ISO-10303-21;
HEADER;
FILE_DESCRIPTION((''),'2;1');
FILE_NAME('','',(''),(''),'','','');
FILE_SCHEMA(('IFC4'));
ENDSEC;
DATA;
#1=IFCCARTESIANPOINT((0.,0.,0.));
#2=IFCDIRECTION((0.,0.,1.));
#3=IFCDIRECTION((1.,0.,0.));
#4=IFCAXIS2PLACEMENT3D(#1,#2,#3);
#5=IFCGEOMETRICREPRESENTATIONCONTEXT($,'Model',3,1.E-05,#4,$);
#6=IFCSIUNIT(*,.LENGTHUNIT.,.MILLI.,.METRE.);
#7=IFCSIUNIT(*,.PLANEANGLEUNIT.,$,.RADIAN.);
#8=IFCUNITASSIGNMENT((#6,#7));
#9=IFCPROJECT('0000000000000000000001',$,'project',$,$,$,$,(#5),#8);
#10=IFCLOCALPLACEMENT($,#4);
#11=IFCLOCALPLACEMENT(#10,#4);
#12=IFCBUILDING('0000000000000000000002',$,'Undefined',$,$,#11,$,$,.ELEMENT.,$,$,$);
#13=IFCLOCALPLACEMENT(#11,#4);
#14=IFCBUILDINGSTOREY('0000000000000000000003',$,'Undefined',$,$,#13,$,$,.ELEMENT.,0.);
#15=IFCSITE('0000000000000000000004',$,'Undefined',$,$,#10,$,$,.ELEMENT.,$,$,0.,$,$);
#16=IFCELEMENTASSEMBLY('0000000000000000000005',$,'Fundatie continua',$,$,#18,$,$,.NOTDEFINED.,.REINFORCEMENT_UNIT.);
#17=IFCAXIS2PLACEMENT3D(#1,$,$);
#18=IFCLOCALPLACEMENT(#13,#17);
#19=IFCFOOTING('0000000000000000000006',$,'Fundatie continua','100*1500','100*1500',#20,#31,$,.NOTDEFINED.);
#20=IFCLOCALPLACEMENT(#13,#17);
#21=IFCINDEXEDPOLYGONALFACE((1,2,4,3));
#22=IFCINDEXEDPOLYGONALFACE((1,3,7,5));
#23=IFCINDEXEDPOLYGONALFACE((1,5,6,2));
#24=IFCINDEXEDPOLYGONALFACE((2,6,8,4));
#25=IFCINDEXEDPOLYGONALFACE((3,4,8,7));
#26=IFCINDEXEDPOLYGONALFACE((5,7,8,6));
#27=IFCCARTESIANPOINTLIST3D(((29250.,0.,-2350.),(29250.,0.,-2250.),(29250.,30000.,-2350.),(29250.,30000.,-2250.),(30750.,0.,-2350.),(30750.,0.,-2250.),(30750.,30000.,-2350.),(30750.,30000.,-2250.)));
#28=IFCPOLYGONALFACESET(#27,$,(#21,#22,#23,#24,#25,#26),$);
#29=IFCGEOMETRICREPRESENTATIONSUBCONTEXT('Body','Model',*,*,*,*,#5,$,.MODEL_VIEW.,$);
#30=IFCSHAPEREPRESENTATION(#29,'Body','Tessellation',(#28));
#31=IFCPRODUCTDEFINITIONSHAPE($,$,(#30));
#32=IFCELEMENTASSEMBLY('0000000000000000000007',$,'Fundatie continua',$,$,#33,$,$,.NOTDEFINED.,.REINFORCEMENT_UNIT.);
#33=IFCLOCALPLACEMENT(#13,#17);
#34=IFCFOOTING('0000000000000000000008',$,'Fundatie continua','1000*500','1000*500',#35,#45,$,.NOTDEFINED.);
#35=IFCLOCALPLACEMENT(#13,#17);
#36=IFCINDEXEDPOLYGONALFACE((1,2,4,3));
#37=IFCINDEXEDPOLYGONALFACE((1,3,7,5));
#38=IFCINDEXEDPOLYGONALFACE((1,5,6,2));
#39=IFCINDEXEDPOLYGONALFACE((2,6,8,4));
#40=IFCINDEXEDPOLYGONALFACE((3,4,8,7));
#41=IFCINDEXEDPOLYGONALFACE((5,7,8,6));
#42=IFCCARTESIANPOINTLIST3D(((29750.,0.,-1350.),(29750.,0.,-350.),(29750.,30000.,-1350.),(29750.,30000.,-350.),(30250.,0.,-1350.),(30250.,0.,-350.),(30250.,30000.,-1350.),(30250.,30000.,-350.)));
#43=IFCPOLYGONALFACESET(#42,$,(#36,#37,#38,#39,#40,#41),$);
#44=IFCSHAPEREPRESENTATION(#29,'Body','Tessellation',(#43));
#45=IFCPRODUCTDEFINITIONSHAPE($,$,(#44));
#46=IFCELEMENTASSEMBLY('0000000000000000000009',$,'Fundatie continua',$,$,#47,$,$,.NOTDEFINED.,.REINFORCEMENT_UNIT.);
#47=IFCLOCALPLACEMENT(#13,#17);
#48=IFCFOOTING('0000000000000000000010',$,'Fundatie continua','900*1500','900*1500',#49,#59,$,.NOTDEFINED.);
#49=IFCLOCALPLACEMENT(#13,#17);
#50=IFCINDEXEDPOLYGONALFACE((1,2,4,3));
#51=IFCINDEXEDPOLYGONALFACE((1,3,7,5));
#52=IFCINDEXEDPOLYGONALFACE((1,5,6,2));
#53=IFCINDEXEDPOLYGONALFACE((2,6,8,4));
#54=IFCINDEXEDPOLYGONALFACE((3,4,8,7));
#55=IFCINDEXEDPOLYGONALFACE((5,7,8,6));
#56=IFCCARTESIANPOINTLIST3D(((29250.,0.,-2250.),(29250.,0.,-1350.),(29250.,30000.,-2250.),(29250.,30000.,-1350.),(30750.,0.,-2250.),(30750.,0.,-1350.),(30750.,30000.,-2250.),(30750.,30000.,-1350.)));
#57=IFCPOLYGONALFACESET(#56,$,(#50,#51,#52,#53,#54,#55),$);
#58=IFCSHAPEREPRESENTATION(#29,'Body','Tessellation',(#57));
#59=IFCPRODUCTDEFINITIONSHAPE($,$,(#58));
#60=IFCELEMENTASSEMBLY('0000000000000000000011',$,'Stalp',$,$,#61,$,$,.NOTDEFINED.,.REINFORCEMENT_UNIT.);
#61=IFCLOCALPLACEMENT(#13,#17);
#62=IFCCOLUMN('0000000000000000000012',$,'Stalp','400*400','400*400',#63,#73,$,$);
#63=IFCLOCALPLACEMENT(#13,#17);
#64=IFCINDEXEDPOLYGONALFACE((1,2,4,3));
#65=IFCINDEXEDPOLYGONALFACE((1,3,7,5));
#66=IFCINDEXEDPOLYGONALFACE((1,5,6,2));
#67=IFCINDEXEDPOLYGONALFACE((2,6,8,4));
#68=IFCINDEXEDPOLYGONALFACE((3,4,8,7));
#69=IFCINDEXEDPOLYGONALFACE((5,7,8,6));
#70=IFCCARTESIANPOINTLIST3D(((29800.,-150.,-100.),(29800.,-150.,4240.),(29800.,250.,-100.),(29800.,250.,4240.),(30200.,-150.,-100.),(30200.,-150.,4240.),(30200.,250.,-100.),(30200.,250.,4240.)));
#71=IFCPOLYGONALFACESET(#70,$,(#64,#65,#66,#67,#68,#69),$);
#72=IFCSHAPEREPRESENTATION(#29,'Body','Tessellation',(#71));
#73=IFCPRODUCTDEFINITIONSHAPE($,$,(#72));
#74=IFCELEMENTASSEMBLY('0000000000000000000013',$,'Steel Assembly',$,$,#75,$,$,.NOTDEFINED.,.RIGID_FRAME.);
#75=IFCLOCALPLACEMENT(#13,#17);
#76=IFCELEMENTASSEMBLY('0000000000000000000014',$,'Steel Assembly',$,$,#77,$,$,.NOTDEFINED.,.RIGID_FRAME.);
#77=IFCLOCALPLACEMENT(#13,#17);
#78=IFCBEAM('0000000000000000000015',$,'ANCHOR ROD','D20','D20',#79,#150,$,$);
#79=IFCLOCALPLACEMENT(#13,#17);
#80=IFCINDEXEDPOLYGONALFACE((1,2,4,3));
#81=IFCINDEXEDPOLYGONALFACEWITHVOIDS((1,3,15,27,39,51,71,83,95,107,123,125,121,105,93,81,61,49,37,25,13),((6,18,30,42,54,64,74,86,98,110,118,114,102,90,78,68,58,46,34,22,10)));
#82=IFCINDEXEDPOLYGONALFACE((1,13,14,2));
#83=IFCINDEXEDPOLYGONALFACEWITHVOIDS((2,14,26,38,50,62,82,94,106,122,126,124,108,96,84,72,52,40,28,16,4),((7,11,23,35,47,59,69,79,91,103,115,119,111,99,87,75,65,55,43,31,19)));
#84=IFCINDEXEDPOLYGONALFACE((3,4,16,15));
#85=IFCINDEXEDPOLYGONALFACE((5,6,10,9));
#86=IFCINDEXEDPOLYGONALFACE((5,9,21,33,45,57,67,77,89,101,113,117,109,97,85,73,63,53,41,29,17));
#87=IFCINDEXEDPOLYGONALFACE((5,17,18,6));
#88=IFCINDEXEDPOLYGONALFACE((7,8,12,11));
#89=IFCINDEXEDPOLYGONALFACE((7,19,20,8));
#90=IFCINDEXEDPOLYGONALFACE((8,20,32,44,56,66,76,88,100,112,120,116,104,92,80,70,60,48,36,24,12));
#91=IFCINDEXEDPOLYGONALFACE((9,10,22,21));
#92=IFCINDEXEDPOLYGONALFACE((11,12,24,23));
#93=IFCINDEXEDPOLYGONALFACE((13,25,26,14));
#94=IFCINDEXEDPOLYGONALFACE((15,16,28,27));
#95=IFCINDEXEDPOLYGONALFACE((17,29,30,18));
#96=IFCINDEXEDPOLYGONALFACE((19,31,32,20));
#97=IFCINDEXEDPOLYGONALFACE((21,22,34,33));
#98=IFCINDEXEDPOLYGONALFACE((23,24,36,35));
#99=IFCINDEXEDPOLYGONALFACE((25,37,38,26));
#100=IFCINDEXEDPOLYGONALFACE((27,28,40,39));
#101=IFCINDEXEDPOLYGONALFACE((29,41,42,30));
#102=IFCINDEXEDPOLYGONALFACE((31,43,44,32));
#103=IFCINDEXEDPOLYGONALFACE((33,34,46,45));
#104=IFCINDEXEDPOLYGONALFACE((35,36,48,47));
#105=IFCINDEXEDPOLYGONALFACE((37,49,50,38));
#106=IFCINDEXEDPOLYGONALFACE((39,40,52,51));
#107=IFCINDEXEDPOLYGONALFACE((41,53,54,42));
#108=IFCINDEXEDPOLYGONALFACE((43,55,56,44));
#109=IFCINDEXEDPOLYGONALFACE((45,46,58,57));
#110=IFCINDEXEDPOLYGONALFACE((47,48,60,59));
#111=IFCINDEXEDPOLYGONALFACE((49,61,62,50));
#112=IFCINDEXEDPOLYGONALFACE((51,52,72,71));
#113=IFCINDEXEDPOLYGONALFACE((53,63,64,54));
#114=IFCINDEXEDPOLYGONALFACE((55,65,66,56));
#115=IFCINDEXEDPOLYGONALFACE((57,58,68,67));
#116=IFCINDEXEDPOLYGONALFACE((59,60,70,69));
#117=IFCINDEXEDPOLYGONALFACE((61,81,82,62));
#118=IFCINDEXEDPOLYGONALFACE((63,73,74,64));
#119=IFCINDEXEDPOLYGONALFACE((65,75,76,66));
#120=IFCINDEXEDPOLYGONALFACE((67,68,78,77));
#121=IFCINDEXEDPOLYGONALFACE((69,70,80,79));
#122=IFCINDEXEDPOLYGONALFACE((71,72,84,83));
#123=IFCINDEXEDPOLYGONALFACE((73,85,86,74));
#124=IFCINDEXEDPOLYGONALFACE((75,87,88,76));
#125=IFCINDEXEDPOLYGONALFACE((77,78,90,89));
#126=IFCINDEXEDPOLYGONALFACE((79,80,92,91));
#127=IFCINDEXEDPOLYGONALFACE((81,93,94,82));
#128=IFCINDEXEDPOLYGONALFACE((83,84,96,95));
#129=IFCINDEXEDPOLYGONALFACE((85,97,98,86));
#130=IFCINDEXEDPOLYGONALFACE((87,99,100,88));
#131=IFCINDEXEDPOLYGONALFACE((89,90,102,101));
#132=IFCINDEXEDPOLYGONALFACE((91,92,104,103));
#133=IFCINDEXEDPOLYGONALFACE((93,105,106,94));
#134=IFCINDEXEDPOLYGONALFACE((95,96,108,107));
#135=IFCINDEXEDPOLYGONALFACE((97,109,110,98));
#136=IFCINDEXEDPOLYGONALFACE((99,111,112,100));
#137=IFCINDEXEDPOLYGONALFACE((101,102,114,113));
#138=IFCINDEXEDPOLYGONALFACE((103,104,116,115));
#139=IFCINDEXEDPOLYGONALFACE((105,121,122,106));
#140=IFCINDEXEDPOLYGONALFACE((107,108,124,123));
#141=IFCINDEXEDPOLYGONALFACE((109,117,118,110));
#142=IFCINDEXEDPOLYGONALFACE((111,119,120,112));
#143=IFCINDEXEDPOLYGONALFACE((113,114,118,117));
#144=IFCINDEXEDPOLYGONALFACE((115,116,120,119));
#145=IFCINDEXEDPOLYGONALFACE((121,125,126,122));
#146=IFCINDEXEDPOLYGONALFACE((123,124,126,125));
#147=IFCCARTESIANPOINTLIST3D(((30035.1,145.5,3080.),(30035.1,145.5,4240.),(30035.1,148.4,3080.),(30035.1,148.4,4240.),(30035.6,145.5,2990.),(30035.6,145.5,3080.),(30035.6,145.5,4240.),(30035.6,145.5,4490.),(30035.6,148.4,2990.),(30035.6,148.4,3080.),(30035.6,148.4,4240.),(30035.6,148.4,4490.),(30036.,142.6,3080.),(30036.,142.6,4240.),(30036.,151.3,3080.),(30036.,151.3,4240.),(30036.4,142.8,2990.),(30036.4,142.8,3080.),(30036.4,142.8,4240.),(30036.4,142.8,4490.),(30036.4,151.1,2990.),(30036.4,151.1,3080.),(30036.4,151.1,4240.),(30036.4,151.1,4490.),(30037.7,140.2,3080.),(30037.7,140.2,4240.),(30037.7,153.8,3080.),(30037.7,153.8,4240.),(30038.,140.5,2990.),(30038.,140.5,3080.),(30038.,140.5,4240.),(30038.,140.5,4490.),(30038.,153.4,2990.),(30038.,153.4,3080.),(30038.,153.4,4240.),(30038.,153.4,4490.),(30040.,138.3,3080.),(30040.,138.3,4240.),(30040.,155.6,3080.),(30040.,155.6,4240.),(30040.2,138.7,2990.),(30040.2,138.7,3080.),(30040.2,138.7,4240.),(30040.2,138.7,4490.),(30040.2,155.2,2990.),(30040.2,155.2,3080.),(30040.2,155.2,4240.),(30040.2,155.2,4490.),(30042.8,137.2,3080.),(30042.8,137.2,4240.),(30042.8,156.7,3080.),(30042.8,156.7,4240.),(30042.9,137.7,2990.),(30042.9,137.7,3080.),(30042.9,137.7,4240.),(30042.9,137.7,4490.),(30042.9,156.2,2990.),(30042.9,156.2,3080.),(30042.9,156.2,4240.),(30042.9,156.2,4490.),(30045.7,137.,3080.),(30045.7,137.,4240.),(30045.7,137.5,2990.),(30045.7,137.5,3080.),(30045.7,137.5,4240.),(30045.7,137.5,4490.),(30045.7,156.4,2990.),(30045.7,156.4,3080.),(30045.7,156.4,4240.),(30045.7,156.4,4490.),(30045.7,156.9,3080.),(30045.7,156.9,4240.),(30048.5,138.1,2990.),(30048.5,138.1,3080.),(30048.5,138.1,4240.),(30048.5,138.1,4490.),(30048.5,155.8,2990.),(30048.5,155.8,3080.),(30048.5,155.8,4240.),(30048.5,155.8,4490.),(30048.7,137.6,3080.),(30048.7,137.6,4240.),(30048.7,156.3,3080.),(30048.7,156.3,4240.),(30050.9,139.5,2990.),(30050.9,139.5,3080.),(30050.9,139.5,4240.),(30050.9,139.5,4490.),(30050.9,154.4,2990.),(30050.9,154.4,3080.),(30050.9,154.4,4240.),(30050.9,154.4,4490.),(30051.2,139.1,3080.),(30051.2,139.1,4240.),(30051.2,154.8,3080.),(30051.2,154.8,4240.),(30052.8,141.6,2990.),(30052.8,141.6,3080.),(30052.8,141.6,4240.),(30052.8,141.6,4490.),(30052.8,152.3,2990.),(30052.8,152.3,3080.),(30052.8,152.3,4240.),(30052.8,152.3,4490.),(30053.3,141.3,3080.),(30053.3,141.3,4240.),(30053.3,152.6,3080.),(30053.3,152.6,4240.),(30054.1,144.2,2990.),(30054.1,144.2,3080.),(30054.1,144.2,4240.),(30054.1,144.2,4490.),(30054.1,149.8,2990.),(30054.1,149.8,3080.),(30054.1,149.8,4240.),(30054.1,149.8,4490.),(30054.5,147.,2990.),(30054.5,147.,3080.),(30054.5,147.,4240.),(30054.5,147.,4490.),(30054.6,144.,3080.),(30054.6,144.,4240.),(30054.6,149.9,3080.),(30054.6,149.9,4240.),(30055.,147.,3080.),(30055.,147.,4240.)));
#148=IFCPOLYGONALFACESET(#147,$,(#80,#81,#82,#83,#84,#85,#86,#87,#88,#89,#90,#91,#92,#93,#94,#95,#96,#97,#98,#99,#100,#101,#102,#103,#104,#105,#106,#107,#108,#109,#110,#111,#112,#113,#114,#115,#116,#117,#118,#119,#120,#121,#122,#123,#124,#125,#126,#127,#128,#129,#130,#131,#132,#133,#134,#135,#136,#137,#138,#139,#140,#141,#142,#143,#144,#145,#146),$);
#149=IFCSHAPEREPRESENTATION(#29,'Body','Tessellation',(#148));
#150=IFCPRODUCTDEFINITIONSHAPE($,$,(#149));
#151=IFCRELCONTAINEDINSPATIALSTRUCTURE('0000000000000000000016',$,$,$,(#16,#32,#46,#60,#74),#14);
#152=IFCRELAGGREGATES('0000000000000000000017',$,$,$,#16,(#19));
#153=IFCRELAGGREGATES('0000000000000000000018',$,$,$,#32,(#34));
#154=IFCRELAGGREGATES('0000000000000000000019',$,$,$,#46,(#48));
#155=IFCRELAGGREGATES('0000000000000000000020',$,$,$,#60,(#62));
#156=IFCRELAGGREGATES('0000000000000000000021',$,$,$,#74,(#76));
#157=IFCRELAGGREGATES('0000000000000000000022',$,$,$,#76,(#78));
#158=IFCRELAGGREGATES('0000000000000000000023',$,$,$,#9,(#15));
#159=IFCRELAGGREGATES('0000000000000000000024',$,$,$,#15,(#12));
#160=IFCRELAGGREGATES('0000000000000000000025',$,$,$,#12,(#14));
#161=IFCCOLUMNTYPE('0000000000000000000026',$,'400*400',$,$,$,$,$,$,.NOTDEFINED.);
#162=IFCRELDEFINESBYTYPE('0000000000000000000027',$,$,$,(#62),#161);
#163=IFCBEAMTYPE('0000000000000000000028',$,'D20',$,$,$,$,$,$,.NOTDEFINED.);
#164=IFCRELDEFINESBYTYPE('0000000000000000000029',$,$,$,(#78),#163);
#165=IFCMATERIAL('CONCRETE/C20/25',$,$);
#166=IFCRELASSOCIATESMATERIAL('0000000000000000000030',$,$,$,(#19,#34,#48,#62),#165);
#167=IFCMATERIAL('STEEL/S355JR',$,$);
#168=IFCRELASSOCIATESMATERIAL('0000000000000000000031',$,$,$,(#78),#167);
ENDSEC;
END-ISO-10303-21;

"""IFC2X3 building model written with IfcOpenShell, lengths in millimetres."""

from ifc_helpers import new_model, si_unit, frame, origin_with_axes, origin_2d_with_axis, place, context, subcontext, project, spatial, rectangle, circle, extrude, boolean, material, type_object, element, aggregate, save


model = new_model("IFC2X3")

# Units and contexts
model_context = context("Model", 3, precision=1e-05, world=origin_with_axes())
body_context = subcontext(model_context, "Body", "Model", "MODEL_VIEW")
ifc_project = project(units=[si_unit("LENGTHUNIT", "METRE", prefix="MILLI"), si_unit("PLANEANGLEUNIT", "RADIAN")], contexts=[model_context])

# Site, building, storey
site_placement = place(None, origin_with_axes())
site = spatial("IfcSite", under=ifc_project, at=site_placement, Name="Undefined", CompositionType="ELEMENT", RefElevation=0.0)
building_placement = place(site_placement, origin_with_axes())
building = spatial("IfcBuilding", under=site, at=building_placement, Name="Undefined", CompositionType="ELEMENT")
storey_placement = place(building_placement, origin_with_axes())
storey = spatial("IfcBuildingStorey", under=building, at=storey_placement, Name="Undefined", CompositionType="ELEMENT", Elevation=0.0)

# Element assemblies, footings
assembly_1_placement = place(storey_placement, origin_with_axes())
assembly_1 = element("IfcElementAssembly", 1, at=assembly_1_placement, inside=storey, Name="Fundatie continua", AssemblyPlace="NOTDEFINED", PredefinedType="REINFORCEMENT_UNIT")
ifc_material_1 = material(Name="CONCRETE/C20/25")
footing_1_placement = place(assembly_1_placement, frame((30000.0, 0.0, -2300.0), z_axis=(0.0, 0.0, 1.0), x_axis=(0.0, 1.0, 0.0)))
footing_1 = element("IfcFooting", 2, at=footing_1_placement, material=ifc_material_1, Name="Fundatie continua", Description="100*1500", ObjectType="100*1500", PredefinedType="NOTDEFINED", context=body_context, shape_type="SweptSolid", body=[
    extrude(rectangle(XDim=1500.0, YDim=100.0, at=origin_2d_with_axis()), frame((30000.0, 0.0, 0.0), z_axis=(-1.0, 0.0, 0.0), x_axis=(0.0, -1.0, 0.0)), (0.0, 0.0, 1.0), 30000.0),
])
aggregate(assembly_1, [footing_1])
assembly_2_placement = place(storey_placement, origin_with_axes())
assembly_2 = element("IfcElementAssembly", 3, at=assembly_2_placement, inside=storey, Name="Fundatie continua", AssemblyPlace="NOTDEFINED", PredefinedType="REINFORCEMENT_UNIT")
footing_2_placement = place(assembly_2_placement, frame((30000.0, 0.0, -850.0), z_axis=(0.0, 0.0, 1.0), x_axis=(0.0, 1.0, 0.0)))
footing_2 = element("IfcFooting", 4, at=footing_2_placement, material=ifc_material_1, Name="Fundatie continua", Description="1000*500", ObjectType="1000*500", PredefinedType="NOTDEFINED", context=body_context, shape_type="SweptSolid", body=[
    extrude(rectangle(XDim=500.0, YDim=1000.0, at=origin_2d_with_axis()), frame((30000.0, 0.0, 0.0), z_axis=(-1.0, 0.0, 0.0), x_axis=(0.0, -1.0, 0.0)), (0.0, 0.0, 1.0), 30000.0),
])
aggregate(assembly_2, [footing_2])
assembly_3_placement = place(storey_placement, origin_with_axes())
assembly_3 = element("IfcElementAssembly", 5, at=assembly_3_placement, inside=storey, Name="Fundatie continua", AssemblyPlace="NOTDEFINED", PredefinedType="REINFORCEMENT_UNIT")
footing_3_placement = place(assembly_3_placement, frame((30000.0, 0.0, -1800.0), z_axis=(0.0, 0.0, 1.0), x_axis=(0.0, 1.0, 0.0)))
footing_3 = element("IfcFooting", 6, at=footing_3_placement, material=ifc_material_1, Name="Fundatie continua", Description="900*1500", ObjectType="900*1500", PredefinedType="NOTDEFINED", context=body_context, shape_type="SweptSolid", body=[
    extrude(rectangle(XDim=1500.0, YDim=900.0, at=origin_2d_with_axis()), frame((30000.0, 0.0, 0.0), z_axis=(-1.0, 0.0, 0.0), x_axis=(0.0, -1.0, 0.0)), (0.0, 0.0, 1.0), 30000.0),
])
aggregate(assembly_3, [footing_3])

# Element assembly, column
assembly_4_placement = place(storey_placement, origin_with_axes())
assembly_4 = element("IfcElementAssembly", 7, at=assembly_4_placement, inside=storey, Name="Stalp", AssemblyPlace="NOTDEFINED", PredefinedType="REINFORCEMENT_UNIT")
column_type = type_object("IfcColumnType", Name="400*400", PredefinedType="NOTDEFINED")
column_placement = place(assembly_4_placement, frame((30000.0, 50.0, -100.0), z_axis=(0.0, 0.0, 1.0), x_axis=(0.0, 1.0, 0.0)))
column = element("IfcColumn", 8, at=column_placement, type_object=column_type, material=ifc_material_1, Name="Stalp", Description="400*400", ObjectType="400*400", context=body_context, shape_type="SweptSolid", body=[
    extrude(rectangle(XDim=400.0, YDim=400.0, at=origin_2d_with_axis()), frame((0.0, 0.0, 4340.0), z_axis=(0.0, 0.0, -1.0), x_axis=(0.0, 1.0, 0.0)), (0.0, 0.0, 1.0), 4340.0),
])
aggregate(assembly_4, [column])

# Element assemblies, beam
assembly_5_placement = place(storey_placement, origin_with_axes())
assembly_5 = element("IfcElementAssembly", 9, at=assembly_5_placement, inside=storey, Name="Steel Assembly", AssemblyPlace="NOTDEFINED", PredefinedType="RIGID_FRAME")
assembly_6_placement = place(assembly_5_placement, origin_with_axes())
assembly_6 = element("IfcElementAssembly", 10, at=assembly_6_placement, Name="Steel Assembly", AssemblyPlace="NOTDEFINED", PredefinedType="RIGID_FRAME")
ifc_material_2 = material(Name="STEEL/S355JR")
beam_type = type_object("IfcBeamType", Name="D20", PredefinedType="NOTDEFINED")
beam_1_placement = place(assembly_6_placement, frame((30045.0, 147.0, 4240.0), z_axis=(0.0, 1.0, 0.0), x_axis=(0.0, 0.0, -1.0)))
beam_1 = element("IfcBeam", 11, at=beam_1_placement, type_object=beam_type, material=ifc_material_2, Name="ANCHOR ROD", Description="D20", ObjectType="D20", context=body_context, shape_type="CSG", body=[
    boolean("UNION", boolean("UNION", extrude(circle(Radius=10.0, at=origin_2d_with_axis()), frame((1160.0, 0.0, 0.0), z_axis=(-1.0, 0.0, 0.0), x_axis=(0.0, -1.0, 0.0)), (0.0, 0.0, 1.0), 1160.0), extrude(circle(Radius=9.5, at=origin_2d_with_axis()), frame((1250.0, 0.0, 0.0), z_axis=(-1.0, 0.0, 0.0), x_axis=(0.0, -1.0, 0.0)), (0.0, 0.0, 1.0), 90.0)), extrude(circle(Radius=9.5, at=origin_2d_with_axis()), frame((0.0, 0.0, 0.0), z_axis=(-1.0, 0.0, 0.0), x_axis=(0.0, -1.0, 0.0)), (0.0, 0.0, 1.0), 250.0)),
])

aggregate(assembly_5, [assembly_6])

aggregate(assembly_6, [beam_1])

save(model, "model.ifc")
